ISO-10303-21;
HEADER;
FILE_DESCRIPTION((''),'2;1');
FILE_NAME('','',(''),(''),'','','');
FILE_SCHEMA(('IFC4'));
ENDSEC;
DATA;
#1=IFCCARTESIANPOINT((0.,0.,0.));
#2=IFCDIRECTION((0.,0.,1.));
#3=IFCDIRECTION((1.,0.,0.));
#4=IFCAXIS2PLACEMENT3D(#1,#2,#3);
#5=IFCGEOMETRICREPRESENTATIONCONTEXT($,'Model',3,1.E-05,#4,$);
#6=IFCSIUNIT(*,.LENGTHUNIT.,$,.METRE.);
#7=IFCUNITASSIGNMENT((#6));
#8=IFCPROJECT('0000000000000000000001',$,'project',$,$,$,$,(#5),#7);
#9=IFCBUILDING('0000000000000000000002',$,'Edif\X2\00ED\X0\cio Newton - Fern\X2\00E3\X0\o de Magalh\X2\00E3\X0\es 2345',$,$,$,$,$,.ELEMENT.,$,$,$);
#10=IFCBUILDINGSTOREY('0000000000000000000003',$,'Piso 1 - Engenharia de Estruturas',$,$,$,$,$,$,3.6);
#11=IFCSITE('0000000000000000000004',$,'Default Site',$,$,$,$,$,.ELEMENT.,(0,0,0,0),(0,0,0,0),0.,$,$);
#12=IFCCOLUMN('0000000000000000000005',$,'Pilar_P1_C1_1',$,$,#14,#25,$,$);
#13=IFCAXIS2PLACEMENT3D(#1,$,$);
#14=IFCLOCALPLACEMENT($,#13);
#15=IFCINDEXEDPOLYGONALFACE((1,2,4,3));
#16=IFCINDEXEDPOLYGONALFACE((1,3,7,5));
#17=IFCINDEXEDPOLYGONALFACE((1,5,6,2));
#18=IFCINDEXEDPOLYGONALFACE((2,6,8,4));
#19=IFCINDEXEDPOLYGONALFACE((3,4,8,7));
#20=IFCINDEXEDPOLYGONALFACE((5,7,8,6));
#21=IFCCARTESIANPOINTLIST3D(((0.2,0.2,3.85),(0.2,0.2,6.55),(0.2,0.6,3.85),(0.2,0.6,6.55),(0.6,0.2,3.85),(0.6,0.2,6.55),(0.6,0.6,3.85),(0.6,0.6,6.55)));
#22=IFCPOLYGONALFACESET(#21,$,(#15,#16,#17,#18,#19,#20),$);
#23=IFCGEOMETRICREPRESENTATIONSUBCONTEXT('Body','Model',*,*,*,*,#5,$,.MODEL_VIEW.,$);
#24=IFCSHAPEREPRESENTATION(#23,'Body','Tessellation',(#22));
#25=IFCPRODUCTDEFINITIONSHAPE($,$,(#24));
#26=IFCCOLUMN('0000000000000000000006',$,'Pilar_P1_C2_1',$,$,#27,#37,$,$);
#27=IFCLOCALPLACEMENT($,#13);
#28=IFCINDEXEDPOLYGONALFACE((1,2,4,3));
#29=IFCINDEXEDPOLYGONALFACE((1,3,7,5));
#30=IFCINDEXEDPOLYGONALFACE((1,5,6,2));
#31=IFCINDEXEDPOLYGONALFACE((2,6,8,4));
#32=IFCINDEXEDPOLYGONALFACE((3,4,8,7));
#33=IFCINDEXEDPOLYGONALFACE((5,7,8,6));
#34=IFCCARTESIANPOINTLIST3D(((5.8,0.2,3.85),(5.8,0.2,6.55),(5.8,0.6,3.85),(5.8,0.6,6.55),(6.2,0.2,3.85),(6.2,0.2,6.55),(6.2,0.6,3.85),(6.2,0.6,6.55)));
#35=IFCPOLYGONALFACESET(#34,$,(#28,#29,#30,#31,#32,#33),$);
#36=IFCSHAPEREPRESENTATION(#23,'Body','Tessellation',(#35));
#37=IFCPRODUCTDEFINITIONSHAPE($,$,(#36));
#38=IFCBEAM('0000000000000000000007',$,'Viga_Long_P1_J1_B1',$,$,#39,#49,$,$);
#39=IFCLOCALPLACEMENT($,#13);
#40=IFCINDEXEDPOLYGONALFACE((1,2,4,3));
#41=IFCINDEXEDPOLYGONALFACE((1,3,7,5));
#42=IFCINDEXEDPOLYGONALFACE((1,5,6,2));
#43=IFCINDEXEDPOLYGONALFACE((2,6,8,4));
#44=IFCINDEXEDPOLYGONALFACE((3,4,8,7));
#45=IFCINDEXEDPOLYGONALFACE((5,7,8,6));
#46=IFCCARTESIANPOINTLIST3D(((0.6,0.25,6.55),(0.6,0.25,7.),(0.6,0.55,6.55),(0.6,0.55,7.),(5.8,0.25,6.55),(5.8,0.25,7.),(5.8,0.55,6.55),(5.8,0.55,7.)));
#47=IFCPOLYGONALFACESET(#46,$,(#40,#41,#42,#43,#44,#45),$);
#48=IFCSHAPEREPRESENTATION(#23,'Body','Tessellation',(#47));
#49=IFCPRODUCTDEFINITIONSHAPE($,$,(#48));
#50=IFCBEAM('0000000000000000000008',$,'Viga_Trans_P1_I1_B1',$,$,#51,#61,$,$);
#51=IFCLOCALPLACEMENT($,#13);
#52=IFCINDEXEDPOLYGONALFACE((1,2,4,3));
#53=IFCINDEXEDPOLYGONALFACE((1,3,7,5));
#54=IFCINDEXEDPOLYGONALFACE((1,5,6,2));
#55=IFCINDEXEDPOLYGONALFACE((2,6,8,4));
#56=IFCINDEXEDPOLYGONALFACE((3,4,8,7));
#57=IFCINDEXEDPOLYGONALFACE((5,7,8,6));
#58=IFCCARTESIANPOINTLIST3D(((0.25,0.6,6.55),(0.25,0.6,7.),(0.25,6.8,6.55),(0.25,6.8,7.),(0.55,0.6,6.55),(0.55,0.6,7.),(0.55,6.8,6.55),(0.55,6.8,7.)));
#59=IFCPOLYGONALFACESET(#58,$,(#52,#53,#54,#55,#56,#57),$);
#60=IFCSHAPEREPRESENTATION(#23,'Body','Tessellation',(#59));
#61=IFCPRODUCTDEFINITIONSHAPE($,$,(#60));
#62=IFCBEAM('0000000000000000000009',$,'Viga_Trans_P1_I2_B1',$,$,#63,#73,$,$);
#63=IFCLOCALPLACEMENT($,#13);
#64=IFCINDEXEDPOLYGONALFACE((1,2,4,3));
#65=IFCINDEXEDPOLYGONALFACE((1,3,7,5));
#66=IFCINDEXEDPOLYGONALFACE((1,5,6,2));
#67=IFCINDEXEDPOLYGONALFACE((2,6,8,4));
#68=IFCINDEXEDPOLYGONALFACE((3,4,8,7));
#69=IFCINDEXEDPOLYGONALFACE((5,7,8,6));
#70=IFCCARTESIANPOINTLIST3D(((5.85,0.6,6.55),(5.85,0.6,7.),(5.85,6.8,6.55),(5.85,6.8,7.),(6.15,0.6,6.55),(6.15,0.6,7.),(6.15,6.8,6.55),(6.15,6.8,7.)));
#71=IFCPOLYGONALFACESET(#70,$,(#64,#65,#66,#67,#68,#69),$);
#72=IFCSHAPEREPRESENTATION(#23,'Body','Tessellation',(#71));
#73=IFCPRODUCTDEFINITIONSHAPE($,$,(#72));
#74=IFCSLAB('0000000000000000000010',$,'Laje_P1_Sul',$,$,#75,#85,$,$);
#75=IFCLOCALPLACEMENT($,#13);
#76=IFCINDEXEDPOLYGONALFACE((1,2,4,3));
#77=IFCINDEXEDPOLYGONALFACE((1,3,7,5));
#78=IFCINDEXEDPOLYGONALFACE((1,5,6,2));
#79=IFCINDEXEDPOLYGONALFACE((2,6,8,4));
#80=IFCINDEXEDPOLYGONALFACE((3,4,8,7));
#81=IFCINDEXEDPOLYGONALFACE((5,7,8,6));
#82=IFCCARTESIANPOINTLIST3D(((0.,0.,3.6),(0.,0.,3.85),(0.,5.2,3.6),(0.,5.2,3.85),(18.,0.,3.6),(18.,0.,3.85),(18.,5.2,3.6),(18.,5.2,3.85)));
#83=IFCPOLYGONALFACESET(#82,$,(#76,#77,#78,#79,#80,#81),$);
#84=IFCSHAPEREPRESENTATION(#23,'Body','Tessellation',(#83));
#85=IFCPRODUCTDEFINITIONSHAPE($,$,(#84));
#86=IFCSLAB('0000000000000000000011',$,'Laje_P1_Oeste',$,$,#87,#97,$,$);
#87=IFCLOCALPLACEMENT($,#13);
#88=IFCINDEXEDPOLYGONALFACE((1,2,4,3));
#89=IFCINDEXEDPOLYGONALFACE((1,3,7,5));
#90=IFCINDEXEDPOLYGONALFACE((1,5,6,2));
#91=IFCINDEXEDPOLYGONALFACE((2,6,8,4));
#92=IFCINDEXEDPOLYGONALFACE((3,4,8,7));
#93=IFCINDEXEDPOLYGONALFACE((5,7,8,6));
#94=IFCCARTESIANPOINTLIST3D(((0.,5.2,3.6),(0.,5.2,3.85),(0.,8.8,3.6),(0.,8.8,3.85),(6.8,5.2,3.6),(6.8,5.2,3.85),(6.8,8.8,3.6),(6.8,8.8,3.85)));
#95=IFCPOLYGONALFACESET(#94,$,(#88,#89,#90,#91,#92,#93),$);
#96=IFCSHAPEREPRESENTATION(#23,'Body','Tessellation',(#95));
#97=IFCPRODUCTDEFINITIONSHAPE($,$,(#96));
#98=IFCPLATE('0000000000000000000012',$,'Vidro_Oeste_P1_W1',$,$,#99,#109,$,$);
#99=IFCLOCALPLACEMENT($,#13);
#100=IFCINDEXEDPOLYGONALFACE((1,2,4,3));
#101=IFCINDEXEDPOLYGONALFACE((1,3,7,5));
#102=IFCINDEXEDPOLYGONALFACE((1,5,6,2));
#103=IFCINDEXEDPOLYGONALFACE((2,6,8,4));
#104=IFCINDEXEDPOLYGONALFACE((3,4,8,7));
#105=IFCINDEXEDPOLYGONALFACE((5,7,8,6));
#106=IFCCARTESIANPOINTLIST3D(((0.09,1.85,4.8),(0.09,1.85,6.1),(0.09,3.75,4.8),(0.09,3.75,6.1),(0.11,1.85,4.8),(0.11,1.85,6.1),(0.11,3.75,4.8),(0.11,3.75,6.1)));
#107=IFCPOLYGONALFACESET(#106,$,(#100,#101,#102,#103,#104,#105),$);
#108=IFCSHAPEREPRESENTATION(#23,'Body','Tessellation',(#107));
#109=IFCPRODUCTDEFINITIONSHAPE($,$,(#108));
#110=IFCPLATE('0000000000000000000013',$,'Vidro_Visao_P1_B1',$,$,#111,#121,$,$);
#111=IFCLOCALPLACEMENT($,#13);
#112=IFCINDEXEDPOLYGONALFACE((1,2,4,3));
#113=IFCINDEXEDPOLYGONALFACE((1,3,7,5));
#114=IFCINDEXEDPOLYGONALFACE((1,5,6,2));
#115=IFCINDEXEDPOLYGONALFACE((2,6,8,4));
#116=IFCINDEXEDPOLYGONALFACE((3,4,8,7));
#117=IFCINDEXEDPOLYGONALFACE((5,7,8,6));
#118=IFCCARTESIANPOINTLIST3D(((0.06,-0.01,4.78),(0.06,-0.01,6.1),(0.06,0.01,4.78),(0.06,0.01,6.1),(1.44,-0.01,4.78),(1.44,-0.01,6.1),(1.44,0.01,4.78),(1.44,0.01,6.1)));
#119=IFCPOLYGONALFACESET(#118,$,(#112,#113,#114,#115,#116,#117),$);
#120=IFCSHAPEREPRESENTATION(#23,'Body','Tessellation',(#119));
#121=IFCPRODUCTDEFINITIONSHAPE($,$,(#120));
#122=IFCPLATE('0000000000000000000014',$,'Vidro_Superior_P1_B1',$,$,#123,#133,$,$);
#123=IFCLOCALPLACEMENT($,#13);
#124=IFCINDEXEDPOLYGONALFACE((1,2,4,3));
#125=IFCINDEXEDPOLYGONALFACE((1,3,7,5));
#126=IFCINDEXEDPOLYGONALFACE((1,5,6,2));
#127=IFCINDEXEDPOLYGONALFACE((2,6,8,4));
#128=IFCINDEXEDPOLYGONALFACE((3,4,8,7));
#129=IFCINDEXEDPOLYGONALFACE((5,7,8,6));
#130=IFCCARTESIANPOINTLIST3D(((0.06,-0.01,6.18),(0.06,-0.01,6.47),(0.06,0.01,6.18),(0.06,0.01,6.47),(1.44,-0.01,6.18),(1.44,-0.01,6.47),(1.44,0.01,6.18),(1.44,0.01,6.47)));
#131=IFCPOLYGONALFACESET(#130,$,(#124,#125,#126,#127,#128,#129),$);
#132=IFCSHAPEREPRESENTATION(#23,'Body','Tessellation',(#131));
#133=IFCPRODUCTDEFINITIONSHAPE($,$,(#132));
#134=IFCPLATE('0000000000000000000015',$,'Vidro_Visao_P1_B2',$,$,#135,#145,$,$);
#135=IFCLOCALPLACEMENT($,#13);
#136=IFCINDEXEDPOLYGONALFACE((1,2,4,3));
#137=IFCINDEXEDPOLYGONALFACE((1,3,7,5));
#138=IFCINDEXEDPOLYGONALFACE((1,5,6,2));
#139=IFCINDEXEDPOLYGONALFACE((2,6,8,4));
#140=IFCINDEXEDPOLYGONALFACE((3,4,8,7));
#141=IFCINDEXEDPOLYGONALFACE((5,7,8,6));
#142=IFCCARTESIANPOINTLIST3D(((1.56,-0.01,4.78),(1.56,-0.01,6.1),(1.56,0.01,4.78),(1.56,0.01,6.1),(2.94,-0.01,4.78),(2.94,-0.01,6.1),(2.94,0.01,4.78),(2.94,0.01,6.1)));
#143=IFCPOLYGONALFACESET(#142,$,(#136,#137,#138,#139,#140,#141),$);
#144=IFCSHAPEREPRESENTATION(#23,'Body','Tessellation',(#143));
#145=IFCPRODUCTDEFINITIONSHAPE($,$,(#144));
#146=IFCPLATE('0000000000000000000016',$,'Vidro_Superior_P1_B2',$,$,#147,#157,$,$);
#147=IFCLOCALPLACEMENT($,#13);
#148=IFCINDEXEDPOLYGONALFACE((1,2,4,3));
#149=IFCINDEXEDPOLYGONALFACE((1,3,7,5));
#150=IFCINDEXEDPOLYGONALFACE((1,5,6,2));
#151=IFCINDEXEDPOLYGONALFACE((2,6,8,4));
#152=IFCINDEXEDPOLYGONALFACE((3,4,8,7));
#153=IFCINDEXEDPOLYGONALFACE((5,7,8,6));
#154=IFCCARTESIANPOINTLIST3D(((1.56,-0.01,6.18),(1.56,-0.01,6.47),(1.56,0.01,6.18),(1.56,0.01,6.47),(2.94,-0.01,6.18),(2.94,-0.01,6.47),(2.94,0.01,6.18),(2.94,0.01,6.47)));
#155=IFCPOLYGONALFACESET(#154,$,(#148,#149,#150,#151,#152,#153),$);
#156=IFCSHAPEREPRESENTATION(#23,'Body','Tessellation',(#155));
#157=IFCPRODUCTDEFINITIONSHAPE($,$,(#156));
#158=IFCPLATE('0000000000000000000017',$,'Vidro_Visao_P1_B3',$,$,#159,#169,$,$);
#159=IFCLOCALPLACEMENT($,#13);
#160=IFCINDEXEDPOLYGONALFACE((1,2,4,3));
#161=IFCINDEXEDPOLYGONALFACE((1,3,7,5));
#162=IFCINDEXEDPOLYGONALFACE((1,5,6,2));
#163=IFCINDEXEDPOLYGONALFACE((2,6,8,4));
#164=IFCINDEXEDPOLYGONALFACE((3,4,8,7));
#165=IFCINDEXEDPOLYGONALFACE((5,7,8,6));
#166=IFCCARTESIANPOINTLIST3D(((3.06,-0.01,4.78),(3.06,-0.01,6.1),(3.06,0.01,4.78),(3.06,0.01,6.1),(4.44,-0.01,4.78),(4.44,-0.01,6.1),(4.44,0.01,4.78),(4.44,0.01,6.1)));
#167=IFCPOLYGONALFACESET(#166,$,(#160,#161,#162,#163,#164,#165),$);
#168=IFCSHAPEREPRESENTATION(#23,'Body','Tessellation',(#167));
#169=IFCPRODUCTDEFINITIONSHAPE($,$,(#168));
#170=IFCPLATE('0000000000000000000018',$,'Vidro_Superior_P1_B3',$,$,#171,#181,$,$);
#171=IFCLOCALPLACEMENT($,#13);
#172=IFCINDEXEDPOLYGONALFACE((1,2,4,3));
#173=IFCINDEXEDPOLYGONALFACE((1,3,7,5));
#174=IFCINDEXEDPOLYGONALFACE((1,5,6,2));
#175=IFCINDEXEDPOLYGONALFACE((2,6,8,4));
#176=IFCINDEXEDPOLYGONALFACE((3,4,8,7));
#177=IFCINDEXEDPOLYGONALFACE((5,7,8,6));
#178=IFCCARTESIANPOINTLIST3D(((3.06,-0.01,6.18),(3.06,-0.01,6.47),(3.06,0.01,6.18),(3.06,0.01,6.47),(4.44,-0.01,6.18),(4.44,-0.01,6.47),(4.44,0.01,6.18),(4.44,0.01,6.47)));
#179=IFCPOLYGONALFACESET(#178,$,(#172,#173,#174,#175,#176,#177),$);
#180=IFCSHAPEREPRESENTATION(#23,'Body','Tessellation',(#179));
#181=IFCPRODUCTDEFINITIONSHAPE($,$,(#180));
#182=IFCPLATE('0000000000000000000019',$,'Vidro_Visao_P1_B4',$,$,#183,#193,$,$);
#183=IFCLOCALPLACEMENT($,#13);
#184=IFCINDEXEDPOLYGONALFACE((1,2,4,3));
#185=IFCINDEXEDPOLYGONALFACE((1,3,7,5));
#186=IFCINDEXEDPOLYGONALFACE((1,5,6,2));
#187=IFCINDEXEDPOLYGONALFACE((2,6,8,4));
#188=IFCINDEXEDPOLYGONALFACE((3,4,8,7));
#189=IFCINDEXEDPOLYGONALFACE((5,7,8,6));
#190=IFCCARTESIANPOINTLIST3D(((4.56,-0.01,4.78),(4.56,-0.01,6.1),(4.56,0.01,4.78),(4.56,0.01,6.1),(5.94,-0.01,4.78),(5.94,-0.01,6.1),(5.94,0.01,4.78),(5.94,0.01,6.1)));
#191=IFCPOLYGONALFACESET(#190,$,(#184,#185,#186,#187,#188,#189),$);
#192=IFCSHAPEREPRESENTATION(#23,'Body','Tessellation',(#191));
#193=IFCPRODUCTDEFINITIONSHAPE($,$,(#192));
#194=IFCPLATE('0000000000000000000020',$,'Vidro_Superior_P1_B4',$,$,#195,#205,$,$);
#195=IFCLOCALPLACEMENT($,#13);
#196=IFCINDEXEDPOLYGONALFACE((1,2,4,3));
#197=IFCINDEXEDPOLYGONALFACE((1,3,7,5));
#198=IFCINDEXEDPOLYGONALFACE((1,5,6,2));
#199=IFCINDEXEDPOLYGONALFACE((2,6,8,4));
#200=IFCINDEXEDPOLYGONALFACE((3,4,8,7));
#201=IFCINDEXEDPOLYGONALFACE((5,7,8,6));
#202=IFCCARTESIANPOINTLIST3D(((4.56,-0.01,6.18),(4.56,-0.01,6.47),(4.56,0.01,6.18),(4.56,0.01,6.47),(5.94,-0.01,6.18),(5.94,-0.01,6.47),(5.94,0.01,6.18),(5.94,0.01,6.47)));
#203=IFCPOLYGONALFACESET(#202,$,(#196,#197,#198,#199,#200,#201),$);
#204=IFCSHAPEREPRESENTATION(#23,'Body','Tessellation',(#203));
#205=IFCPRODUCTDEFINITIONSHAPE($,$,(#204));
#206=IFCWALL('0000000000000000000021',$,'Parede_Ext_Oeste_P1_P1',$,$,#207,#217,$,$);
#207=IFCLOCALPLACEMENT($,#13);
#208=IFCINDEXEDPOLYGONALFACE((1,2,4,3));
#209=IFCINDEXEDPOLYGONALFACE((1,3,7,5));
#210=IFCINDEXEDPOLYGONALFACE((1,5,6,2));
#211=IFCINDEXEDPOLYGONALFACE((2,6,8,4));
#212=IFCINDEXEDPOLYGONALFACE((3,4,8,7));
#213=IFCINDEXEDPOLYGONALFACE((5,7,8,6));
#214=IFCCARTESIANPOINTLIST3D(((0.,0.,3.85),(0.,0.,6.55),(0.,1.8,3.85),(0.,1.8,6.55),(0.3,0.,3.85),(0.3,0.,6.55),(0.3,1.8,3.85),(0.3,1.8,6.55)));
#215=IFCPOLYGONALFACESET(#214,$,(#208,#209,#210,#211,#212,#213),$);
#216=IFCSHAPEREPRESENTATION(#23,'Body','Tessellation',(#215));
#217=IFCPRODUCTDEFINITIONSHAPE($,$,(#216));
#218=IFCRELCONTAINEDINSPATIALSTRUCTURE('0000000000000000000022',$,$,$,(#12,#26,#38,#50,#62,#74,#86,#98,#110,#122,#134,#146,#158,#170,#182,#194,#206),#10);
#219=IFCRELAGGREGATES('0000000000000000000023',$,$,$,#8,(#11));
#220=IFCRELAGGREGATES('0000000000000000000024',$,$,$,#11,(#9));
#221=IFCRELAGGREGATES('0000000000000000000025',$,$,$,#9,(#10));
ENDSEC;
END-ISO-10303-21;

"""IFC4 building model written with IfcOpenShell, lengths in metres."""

from ifc_helpers import new_model, si_unit, frame, frame_2d, origin_with_axes, place, context, subcontext, project, spatial, rectangle, extrude, element, save


model = new_model("IFC4")

# Units and contexts
model_context = context("Model", 3, precision=1e-05, world=origin_with_axes())
body_context = subcontext(model_context, "Body", "Model", "MODEL_VIEW")
ifc_project = project(units=[si_unit("LENGTHUNIT", "METRE")], contexts=[model_context])

# Site, building, storey
site = spatial("IfcSite", under=ifc_project, Name="Default Site", CompositionType="ELEMENT", RefLatitude=(0, 0, 0, 0), RefLongitude=(0, 0, 0, 0), RefElevation=0.0)
building = spatial("IfcBuilding", under=site, Name="Edifício Newton - Fernão de Magalhães 2345", CompositionType="ELEMENT")
storey = spatial("IfcBuildingStorey", under=building, Name="Piso 1 - Engenharia de Estruturas", Elevation=3.6)

# Columns
for number, where, z_axis, x_axis, name in (
    (1, (0.2, 0.2, 3.85), (0.0, 0.0, 1.0), (1.0, 0.0, 0.0), "Pilar_P1_C1_1"),
    (2, (5.8, 0.2, 3.85), (0.0, 0.0, 1.0), (1.0, 0.0, 0.0), "Pilar_P1_C2_1"),
):
    element("IfcColumn", number, at=place(None, frame(where, z_axis=z_axis, x_axis=x_axis)), inside=storey, Name=name, context=body_context, shape_type="SweptSolid", body=[
        extrude(rectangle(XDim=0.4, YDim=0.4, at=frame_2d((0.2, 0.2))), origin_with_axes(), (0.0, 0.0, 1.0), 2.7),
    ])

# Beams
beam_placement = place(None, frame((0.6, 0.25, 6.55), z_axis=(0.0, 0.0, 1.0), x_axis=(1.0, 0.0, 0.0)))
element("IfcBeam", 3, at=beam_placement, inside=storey, Name="Viga_Long_P1_J1_B1", context=body_context, shape_type="SweptSolid", body=[
    extrude(rectangle(XDim=5.2, YDim=0.3, at=frame_2d((2.6, 0.15))), origin_with_axes(), (0.0, 0.0, 1.0), 0.45),
])
for number, where, z_axis, x_axis, name in (
    (4, (0.25, 0.6, 6.55), (0.0, 0.0, 1.0), (1.0, 0.0, 0.0), "Viga_Trans_P1_I1_B1"),
    (5, (5.85, 0.6, 6.55), (0.0, 0.0, 1.0), (1.0, 0.0, 0.0), "Viga_Trans_P1_I2_B1"),
):
    element("IfcBeam", number, at=place(None, frame(where, z_axis=z_axis, x_axis=x_axis)), inside=storey, Name=name, context=body_context, shape_type="SweptSolid", body=[
        extrude(rectangle(XDim=0.3, YDim=6.2, at=frame_2d((0.15, 3.1))), origin_with_axes(), (0.0, 0.0, 1.0), 0.45),
    ])

# Slabs
slab_1_placement = place(None, frame((0.0, 0.0, 3.6), z_axis=(0.0, 0.0, 1.0), x_axis=(1.0, 0.0, 0.0)))
element("IfcSlab", 6, at=slab_1_placement, inside=storey, Name="Laje_P1_Sul", context=body_context, shape_type="SweptSolid", body=[
    extrude(rectangle(XDim=18.0, YDim=5.2, at=frame_2d((9.0, 2.6))), origin_with_axes(), (0.0, 0.0, 1.0), 0.25),
])
slab_2_placement = place(None, frame((0.0, 5.2, 3.6), z_axis=(0.0, 0.0, 1.0), x_axis=(1.0, 0.0, 0.0)))
element("IfcSlab", 7, at=slab_2_placement, inside=storey, Name="Laje_P1_Oeste", context=body_context, shape_type="SweptSolid", body=[
    extrude(rectangle(XDim=6.8, YDim=3.6, at=frame_2d((3.4, 1.8))), origin_with_axes(), (0.0, 0.0, 1.0), 0.25),
])

# Plates
plate_1_placement = place(None, frame((0.09, 1.85, 4.8), z_axis=(0.0, 0.0, 1.0), x_axis=(1.0, 0.0, 0.0)))
element("IfcPlate", 8, at=plate_1_placement, inside=storey, Name="Vidro_Oeste_P1_W1", context=body_context, shape_type="SweptSolid", body=[
    extrude(rectangle(XDim=0.02, YDim=1.9, at=frame_2d((0.01, 0.95))), origin_with_axes(), (0.0, 0.0, 1.0), 1.3),
])
plate_2_placement = place(None, frame((0.06, -0.01, 4.78), z_axis=(0.0, 0.0, 1.0), x_axis=(1.0, 0.0, 0.0)))
element("IfcPlate", 9, at=plate_2_placement, inside=storey, Name="Vidro_Visao_P1_B1", context=body_context, shape_type="SweptSolid", body=[
    extrude(rectangle(XDim=1.38, YDim=0.02, at=frame_2d((0.69, 0.01))), origin_with_axes(), (0.0, 0.0, 1.0), 1.32),
])
plate_3_placement = place(None, frame((0.06, -0.01, 6.18), z_axis=(0.0, 0.0, 1.0), x_axis=(1.0, 0.0, 0.0)))
element("IfcPlate", 10, at=plate_3_placement, inside=storey, Name="Vidro_Superior_P1_B1", context=body_context, shape_type="SweptSolid", body=[
    extrude(rectangle(XDim=1.38, YDim=0.02, at=frame_2d((0.69, 0.01))), origin_with_axes(), (0.0, 0.0, 1.0), 0.29),
])
plate_4_placement = place(None, frame((1.56, -0.01, 4.78), z_axis=(0.0, 0.0, 1.0), x_axis=(1.0, 0.0, 0.0)))
element("IfcPlate", 11, at=plate_4_placement, inside=storey, Name="Vidro_Visao_P1_B2", context=body_context, shape_type="SweptSolid", body=[
    extrude(rectangle(XDim=1.38, YDim=0.02, at=frame_2d((0.69, 0.01))), origin_with_axes(), (0.0, 0.0, 1.0), 1.32),
])
plate_5_placement = place(None, frame((1.56, -0.01, 6.18), z_axis=(0.0, 0.0, 1.0), x_axis=(1.0, 0.0, 0.0)))
element("IfcPlate", 12, at=plate_5_placement, inside=storey, Name="Vidro_Superior_P1_B2", context=body_context, shape_type="SweptSolid", body=[
    extrude(rectangle(XDim=1.38, YDim=0.02, at=frame_2d((0.69, 0.01))), origin_with_axes(), (0.0, 0.0, 1.0), 0.29),
])
plate_6_placement = place(None, frame((3.06, -0.01, 4.78), z_axis=(0.0, 0.0, 1.0), x_axis=(1.0, 0.0, 0.0)))
element("IfcPlate", 13, at=plate_6_placement, inside=storey, Name="Vidro_Visao_P1_B3", context=body_context, shape_type="SweptSolid", body=[
    extrude(rectangle(XDim=1.38, YDim=0.02, at=frame_2d((0.69, 0.01))), origin_with_axes(), (0.0, 0.0, 1.0), 1.32),
])
plate_7_placement = place(None, frame((3.06, -0.01, 6.18), z_axis=(0.0, 0.0, 1.0), x_axis=(1.0, 0.0, 0.0)))
element("IfcPlate", 14, at=plate_7_placement, inside=storey, Name="Vidro_Superior_P1_B3", context=body_context, shape_type="SweptSolid", body=[
    extrude(rectangle(XDim=1.38, YDim=0.02, at=frame_2d((0.69, 0.01))), origin_with_axes(), (0.0, 0.0, 1.0), 0.29),
])
plate_8_placement = place(None, frame((4.56, -0.01, 4.78), z_axis=(0.0, 0.0, 1.0), x_axis=(1.0, 0.0, 0.0)))
element("IfcPlate", 15, at=plate_8_placement, inside=storey, Name="Vidro_Visao_P1_B4", context=body_context, shape_type="SweptSolid", body=[
    extrude(rectangle(XDim=1.38, YDim=0.02, at=frame_2d((0.69, 0.01))), origin_with_axes(), (0.0, 0.0, 1.0), 1.32),
])
plate_9_placement = place(None, frame((4.56, -0.01, 6.18), z_axis=(0.0, 0.0, 1.0), x_axis=(1.0, 0.0, 0.0)))
element("IfcPlate", 16, at=plate_9_placement, inside=storey, Name="Vidro_Superior_P1_B4", context=body_context, shape_type="SweptSolid", body=[
    extrude(rectangle(XDim=1.38, YDim=0.02, at=frame_2d((0.69, 0.01))), origin_with_axes(), (0.0, 0.0, 1.0), 0.29),
])

# Wall
wall_1_placement = place(None, frame((0.0, 0.0, 3.85), z_axis=(0.0, 0.0, 1.0), x_axis=(1.0, 0.0, 0.0)))
element("IfcWall", 17, at=wall_1_placement, inside=storey, Name="Parede_Ext_Oeste_P1_P1", context=body_context, shape_type="SweptSolid", body=[
    extrude(rectangle(XDim=0.3, YDim=1.8, at=frame_2d((0.15, 0.9))), origin_with_axes(), (0.0, 0.0, 1.0), 2.7),
])

save(model, "model.ifc")
